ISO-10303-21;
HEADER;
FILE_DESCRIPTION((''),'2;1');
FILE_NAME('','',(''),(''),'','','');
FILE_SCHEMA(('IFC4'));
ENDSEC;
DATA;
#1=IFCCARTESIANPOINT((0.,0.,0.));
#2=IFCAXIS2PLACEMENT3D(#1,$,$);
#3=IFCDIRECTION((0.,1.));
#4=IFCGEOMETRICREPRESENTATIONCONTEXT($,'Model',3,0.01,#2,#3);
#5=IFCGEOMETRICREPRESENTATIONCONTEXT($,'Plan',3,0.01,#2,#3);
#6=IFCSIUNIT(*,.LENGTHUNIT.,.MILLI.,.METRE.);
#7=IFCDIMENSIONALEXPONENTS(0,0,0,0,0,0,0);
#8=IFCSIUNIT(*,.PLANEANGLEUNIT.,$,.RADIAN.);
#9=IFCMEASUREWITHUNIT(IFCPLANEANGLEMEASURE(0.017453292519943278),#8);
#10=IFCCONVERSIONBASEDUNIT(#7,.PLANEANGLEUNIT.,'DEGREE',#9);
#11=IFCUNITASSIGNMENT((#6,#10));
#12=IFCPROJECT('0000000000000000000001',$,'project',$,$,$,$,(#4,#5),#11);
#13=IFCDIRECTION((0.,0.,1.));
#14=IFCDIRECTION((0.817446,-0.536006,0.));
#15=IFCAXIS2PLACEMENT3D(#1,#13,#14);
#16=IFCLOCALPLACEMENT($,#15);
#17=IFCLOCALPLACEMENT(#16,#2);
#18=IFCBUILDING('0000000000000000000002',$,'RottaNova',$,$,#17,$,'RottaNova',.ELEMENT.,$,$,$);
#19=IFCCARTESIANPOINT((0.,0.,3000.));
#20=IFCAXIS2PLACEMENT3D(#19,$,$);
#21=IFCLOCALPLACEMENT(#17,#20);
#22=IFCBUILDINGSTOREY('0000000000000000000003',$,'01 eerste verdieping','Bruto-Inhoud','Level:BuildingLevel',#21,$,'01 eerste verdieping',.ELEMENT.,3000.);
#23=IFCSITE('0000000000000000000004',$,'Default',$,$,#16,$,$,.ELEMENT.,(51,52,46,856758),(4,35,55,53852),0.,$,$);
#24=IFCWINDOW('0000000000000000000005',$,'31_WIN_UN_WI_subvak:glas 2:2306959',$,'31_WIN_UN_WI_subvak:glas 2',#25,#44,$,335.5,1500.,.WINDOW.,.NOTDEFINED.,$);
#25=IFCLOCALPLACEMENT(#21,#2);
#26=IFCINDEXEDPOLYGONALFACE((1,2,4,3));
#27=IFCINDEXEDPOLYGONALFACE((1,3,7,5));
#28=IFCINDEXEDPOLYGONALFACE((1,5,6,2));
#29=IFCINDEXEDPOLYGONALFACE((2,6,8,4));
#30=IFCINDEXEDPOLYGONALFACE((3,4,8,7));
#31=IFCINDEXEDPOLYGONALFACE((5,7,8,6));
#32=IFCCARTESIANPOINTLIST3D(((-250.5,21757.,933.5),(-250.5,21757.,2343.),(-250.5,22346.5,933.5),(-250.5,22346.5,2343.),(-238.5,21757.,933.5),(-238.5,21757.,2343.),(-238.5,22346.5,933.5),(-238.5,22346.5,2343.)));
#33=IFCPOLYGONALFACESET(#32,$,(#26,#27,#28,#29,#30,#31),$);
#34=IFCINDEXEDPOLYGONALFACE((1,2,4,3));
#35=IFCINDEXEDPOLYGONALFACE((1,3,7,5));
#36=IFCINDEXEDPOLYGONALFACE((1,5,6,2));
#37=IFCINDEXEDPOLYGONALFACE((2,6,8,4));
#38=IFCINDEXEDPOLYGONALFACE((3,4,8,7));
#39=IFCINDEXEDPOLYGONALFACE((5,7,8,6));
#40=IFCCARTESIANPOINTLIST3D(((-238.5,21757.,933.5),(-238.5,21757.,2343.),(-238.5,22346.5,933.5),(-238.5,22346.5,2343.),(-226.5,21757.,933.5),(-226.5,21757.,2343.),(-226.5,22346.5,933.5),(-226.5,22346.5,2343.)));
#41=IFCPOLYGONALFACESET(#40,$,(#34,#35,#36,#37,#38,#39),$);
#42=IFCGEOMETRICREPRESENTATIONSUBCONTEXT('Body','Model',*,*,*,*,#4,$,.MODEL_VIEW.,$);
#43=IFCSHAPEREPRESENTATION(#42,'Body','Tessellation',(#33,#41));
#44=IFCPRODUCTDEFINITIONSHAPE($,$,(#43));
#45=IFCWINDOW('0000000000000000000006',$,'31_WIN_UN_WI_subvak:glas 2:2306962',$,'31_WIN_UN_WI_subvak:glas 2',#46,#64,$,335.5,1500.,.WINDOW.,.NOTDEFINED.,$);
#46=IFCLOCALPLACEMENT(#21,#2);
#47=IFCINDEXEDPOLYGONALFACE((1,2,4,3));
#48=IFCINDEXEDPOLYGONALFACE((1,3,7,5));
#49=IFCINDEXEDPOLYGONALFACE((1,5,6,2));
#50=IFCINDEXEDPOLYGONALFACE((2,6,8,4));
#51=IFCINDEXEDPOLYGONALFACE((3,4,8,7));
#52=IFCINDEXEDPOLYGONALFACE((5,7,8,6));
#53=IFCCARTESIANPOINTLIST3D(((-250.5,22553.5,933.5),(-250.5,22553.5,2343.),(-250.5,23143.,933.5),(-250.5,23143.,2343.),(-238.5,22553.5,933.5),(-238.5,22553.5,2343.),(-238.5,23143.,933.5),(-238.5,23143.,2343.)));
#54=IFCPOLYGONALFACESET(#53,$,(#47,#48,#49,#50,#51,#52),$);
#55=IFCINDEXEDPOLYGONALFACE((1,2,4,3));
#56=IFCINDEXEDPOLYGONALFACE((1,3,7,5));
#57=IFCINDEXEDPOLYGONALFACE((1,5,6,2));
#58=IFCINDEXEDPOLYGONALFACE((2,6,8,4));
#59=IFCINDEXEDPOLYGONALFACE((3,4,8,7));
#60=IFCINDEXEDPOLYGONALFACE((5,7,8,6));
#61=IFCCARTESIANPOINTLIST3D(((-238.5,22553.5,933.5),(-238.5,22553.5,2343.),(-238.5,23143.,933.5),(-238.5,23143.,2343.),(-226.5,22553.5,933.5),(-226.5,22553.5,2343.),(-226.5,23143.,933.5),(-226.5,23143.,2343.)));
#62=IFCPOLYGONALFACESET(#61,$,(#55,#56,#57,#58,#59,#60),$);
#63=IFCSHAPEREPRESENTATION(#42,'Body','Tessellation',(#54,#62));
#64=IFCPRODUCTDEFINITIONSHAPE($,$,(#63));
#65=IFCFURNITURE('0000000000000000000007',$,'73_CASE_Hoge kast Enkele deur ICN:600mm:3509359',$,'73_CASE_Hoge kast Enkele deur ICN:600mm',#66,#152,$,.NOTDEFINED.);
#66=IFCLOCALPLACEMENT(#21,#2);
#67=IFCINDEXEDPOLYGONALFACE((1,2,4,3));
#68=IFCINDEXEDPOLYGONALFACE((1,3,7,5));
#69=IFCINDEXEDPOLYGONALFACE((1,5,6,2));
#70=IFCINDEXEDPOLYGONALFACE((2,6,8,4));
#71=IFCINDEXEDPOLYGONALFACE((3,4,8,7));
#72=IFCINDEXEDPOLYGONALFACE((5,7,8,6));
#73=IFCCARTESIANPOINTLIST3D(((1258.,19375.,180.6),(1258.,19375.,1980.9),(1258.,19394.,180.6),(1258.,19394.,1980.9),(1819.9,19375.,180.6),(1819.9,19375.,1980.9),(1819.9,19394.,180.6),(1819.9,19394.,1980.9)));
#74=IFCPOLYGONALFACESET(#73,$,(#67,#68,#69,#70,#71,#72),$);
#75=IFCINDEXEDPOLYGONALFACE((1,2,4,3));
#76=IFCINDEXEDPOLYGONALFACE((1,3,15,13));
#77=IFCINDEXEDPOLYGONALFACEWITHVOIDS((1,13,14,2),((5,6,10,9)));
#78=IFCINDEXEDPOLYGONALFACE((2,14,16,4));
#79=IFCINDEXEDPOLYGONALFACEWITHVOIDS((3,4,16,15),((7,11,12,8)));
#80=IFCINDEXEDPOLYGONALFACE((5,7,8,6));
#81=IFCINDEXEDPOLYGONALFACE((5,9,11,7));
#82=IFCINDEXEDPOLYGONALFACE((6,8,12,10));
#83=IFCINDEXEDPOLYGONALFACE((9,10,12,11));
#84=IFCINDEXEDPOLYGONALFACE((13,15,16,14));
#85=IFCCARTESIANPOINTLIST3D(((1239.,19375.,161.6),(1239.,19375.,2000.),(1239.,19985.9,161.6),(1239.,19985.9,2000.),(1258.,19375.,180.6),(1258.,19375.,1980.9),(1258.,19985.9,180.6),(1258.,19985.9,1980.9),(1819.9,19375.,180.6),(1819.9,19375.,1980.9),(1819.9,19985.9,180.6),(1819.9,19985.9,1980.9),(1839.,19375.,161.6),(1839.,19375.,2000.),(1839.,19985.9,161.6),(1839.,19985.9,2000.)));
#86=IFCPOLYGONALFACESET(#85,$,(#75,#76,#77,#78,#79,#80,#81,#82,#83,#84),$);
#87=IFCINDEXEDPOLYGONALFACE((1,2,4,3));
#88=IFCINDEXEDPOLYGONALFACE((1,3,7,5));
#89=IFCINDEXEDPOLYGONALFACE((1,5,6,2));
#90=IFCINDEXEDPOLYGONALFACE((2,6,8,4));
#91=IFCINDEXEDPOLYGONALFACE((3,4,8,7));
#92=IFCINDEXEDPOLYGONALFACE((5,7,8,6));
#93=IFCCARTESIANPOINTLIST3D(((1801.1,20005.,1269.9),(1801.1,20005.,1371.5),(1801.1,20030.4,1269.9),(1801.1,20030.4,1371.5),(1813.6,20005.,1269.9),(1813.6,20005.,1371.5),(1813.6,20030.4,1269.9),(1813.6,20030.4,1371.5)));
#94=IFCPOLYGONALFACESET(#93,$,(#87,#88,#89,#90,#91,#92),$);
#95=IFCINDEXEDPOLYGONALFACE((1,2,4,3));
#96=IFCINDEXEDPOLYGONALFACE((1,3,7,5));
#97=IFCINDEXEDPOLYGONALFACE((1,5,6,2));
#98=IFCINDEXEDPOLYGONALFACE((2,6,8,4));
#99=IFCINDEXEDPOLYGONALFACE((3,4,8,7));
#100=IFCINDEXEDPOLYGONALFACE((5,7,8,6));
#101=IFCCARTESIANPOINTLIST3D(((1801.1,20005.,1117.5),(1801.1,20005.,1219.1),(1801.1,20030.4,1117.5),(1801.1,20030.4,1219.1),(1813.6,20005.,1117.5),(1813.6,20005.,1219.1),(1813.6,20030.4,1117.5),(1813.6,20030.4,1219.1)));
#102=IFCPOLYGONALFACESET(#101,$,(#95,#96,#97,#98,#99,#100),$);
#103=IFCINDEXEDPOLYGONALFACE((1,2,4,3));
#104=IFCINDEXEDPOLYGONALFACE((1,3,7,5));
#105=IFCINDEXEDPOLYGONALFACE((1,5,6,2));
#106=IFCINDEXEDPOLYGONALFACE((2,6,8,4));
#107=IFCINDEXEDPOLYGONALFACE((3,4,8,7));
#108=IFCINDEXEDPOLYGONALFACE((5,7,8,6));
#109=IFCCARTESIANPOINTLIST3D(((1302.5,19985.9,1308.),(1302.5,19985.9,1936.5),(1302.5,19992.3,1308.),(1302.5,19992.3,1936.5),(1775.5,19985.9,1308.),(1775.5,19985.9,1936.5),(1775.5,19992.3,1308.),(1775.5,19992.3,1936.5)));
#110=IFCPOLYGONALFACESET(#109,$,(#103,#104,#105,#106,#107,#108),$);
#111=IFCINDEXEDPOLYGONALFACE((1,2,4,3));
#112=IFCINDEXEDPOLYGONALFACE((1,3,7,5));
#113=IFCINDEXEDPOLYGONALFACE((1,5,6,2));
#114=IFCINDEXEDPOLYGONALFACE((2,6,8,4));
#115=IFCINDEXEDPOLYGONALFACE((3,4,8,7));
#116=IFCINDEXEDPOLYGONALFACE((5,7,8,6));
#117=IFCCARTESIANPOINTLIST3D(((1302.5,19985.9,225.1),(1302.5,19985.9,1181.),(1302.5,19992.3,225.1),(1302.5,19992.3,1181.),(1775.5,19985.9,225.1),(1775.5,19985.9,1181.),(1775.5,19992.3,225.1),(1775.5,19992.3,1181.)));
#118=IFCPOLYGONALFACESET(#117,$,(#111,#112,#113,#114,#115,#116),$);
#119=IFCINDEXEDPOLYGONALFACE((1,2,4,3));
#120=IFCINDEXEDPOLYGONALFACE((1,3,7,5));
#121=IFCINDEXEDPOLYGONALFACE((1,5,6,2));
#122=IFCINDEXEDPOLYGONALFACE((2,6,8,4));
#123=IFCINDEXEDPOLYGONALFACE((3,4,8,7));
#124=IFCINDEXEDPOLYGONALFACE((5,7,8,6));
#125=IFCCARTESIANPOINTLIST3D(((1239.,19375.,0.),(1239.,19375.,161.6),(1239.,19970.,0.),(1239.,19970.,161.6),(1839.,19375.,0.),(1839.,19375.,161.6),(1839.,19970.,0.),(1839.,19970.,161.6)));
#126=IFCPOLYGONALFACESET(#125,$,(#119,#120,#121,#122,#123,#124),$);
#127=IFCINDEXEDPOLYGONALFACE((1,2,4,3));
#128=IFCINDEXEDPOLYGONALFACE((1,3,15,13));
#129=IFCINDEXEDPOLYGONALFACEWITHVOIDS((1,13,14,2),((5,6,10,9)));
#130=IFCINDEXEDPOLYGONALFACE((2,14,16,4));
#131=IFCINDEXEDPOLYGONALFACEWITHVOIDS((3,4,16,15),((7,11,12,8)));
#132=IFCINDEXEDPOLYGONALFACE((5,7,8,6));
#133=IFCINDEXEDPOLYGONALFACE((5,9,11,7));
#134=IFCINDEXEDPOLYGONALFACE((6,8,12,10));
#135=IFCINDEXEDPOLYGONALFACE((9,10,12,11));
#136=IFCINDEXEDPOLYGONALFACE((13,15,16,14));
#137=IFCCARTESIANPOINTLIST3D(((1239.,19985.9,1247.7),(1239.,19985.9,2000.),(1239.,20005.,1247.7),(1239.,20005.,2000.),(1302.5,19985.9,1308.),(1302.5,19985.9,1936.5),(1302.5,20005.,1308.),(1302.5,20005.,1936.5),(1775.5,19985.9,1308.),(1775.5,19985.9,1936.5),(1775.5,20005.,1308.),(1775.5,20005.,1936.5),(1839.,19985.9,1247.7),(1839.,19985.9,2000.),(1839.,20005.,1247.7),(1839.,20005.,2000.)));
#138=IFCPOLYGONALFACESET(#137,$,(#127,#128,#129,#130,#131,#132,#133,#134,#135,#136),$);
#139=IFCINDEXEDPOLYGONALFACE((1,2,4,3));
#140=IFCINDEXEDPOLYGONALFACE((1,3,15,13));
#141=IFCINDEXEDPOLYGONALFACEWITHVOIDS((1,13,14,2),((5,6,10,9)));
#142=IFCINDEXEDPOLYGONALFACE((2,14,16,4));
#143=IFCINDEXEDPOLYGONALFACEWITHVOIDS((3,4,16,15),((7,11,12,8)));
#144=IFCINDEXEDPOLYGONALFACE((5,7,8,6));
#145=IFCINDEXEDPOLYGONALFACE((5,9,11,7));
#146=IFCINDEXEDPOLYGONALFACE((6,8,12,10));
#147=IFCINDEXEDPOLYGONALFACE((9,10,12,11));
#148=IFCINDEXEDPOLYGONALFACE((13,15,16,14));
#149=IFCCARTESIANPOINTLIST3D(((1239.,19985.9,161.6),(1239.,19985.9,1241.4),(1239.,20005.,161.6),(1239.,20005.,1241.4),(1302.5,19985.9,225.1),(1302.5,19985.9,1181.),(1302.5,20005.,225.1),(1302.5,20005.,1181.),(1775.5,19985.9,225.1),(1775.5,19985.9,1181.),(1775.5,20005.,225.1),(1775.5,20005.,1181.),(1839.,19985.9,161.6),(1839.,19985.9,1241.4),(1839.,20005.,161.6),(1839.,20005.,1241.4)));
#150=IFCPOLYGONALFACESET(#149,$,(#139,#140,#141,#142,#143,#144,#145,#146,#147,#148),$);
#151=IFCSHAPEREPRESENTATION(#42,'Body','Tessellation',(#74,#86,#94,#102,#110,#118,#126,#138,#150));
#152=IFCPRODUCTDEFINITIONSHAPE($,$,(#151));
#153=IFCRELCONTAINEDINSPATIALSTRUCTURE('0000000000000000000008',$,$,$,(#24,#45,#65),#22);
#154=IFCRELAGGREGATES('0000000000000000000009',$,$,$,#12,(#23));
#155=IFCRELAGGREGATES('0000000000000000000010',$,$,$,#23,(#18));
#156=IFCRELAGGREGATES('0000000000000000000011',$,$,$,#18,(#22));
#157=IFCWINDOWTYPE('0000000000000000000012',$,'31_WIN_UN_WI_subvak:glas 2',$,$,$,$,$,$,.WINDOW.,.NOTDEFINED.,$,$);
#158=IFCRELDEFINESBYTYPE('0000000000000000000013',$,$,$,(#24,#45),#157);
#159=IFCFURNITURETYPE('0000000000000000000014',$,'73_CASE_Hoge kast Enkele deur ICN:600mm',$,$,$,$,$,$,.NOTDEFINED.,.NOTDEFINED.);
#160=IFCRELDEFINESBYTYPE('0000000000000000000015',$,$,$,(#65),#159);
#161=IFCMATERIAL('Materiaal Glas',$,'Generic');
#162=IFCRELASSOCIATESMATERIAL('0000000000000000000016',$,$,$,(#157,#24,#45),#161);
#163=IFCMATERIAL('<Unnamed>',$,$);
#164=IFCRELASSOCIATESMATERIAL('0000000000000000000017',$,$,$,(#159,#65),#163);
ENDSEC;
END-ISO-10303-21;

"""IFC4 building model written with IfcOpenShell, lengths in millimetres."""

from ifc_helpers import new_model, entity, si_unit, converted_unit, direction, frame, origin, place, context, subcontext, project, spatial, indexed_curve, outline, extrude, source, transform, mapped, material, type_object, type_shapes, element, save


model = new_model("IFC4")

# Units and contexts
model_context = context("Model", 3, precision=0.01, world=origin(), true_north=direction((0.0, 1.0)))
plan_context = context("Plan", 3, precision=0.01, world=origin(), true_north=direction((0.0, 1.0)))
body_context = subcontext(model_context, "Body", "Model", "MODEL_VIEW")
ifc_project = project(units=[si_unit("LENGTHUNIT", "METRE", prefix="MILLI"), converted_unit("PLANEANGLEUNIT", "DEGREE", entity("IfcPlaneAngleMeasure", 0.017453292519943278), si_unit("PLANEANGLEUNIT", "RADIAN"), dimensions=[0, 0, 0, 0, 0, 0, 0])], contexts=[model_context, plan_context])

# Site, building, storey
site_placement = place(None, frame((0.0, 0.0, 0.0), z_axis=(0.0, 0.0, 1.0), x_axis=(0.817446, -0.536006, 0.0)))
site = spatial("IfcSite", under=ifc_project, at=site_placement, Name="Default", CompositionType="ELEMENT", RefLatitude=(51, 52, 46, 856758), RefLongitude=(4, 35, 55, 53852), RefElevation=0.0)
building_placement = place(site_placement, origin())
building = spatial("IfcBuilding", under=site, at=building_placement, Name="RottaNova", LongName="RottaNova", CompositionType="ELEMENT")
storey_placement = place(building_placement, frame((0.0, 0.0, 3000.0)))
storey = spatial("IfcBuildingStorey", under=building, at=storey_placement, Name="01 eerste verdieping", Description="Bruto-Inhoud", ObjectType="Level:BuildingLevel", LongName="01 eerste verdieping", CompositionType="ELEMENT", Elevation=3000.0)

# Shared definitions
ifc_material_1 = material(Name="Materiaal Glas", Category="Generic")

# Windows
window_type = type_object("IfcWindowType", Name="31_WIN_UN_WI_subvak:glas 2", PartitioningType="NOTDEFINED", PredefinedType="WINDOW", material=ifc_material_1)
shared_shape_1 = source(origin(), body_context, "Body", "SweptSolid", [
    extrude(outline(indexed_curve([(-6.0, -294.7), (6.0, -294.7), (6.0, 294.7), (-6.0, 294.7), (-6.0, -294.7)], self_intersect=False)), frame((0.0, 6.0, 0.0), z_axis=(0.0, 0.0, 1.0), x_axis=(0.0, -1.0, 0.0)), (0.0, 0.0, 1.0), 1409.5),
    extrude(outline(indexed_curve([(-6.0, -294.8), (6.0, -294.8), (6.0, 294.8), (-6.0, 294.8), (-6.0, -294.8)], self_intersect=False)), frame((0.0, -6.0, 0.0), z_axis=(0.0, 0.0, 1.0), x_axis=(0.0, -1.0, 0.0)), (0.0, 0.0, 1.0), 1409.5),
])
type_shapes(window_type, [shared_shape_1])
for number, where, z_axis, x_axis, name in (
    (1, (-238.5, 22051.7, 933.5), (0.0, 0.0, 1.0), (0.0, 1.0, 0.0), "31_WIN_UN_WI_subvak:glas 2:2306959"),
    (2, (-238.5, 22848.2, 933.5), (0.0, 0.0, 1.0), (0.0, 1.0, 0.0), "31_WIN_UN_WI_subvak:glas 2:2306962"),
):
    element("IfcWindow", number, at=place(storey_placement, frame(where, z_axis=z_axis, x_axis=x_axis)), inside=storey, type_object=window_type, material=ifc_material_1, Name=name, ObjectType="31_WIN_UN_WI_subvak:glas 2", OverallHeight=335.5, OverallWidth=1500.0, PartitioningType="NOTDEFINED", PredefinedType="WINDOW", context=body_context, shape_type="MappedRepresentation", body=[
        mapped(shared_shape_1, transform((0.0, 0.0, 0.0), scale=1.0)),
    ])

# Furniture
ifc_material_2 = material(Name="<Unnamed>")
furniture_type = type_object("IfcFurnitureType", Name="73_CASE_Hoge kast Enkele deur ICN:600mm", AssemblyPlace="NOTDEFINED", PredefinedType="NOTDEFINED", material=ifc_material_2)
shared_shape_2 = source(origin(), body_context, "Body", "SweptSolid", [
    extrude(outline(indexed_curve([(-280.9, -9.5), (280.9, -9.5), (280.9, 9.5), (-280.9, 9.5), (-280.9, -9.5)], self_intersect=False)), frame((18.7, 9.5, 180.6), z_axis=(0.0, 0.0, 1.0), x_axis=(-1.0, 0.0, 0.0)), (0.0, 0.0, 1.0), 1800.3),
    extrude(outline(indexed_curve([(-300.0, -919.2), (300.0, -919.2), (300.0, 919.2), (-300.0, 919.2), (-300.0, -919.2)], self_intersect=False), holes=[indexed_curve([(-280.9, 900.2), (281.0, 900.2), (281.0, -900.2), (-280.9, -900.2), (-280.9, 900.2)], self_intersect=False)]), frame((18.7, 0.0, 1080.8), z_axis=(0.0, 1.0, 0.0), x_axis=(-1.0, 0.0, 0.0)), (0.0, 0.0, 1.0), 610.9),
    extrude(outline(indexed_curve([(-6.3, -12.7), (6.3, -12.7), (6.3, 12.7), (-6.3, 12.7), (-6.3, -12.7)], self_intersect=False)), frame((287.1, 642.7, 1269.9), z_axis=(0.0, 0.0, 1.0), x_axis=(-1.0, 0.0, 0.0)), (0.0, 0.0, 1.0), 101.6),
    extrude(outline(indexed_curve([(-6.3, -12.7), (6.3, -12.7), (6.3, 12.7), (-6.3, 12.7), (-6.3, -12.7)], self_intersect=False)), frame((287.1, 642.7, 1117.5), z_axis=(0.0, 0.0, 1.0), x_axis=(-1.0, 0.0, 0.0)), (0.0, 0.0, 1.0), 101.6),
    extrude(outline(indexed_curve([(-236.5, -3.2), (236.5, -3.2), (236.5, 3.2), (-236.5, 3.2), (-236.5, -3.2)], self_intersect=False)), frame((18.7, 614.1, 1308.0), z_axis=(0.0, 0.0, 1.0), x_axis=(-1.0, 0.0, 0.0)), (0.0, 0.0, 1.0), 628.5),
    extrude(outline(indexed_curve([(-236.5, -3.2), (236.5, -3.2), (236.5, 3.2), (-236.5, 3.2), (-236.5, -3.2)], self_intersect=False)), frame((18.7, 614.1, 225.1), z_axis=(0.0, 0.0, 1.0), x_axis=(-1.0, 0.0, 0.0)), (0.0, 0.0, 1.0), 956.0),
    extrude(outline(indexed_curve([(-297.5, -300.0), (297.5, -300.0), (297.5, 300.0), (-297.5, 300.0), (-297.5, -300.0)], self_intersect=False)), frame((18.7, 297.5, 0.0), z_axis=(0.0, 0.0, 1.0), x_axis=(0.0, 1.0, 0.0)), (0.0, 0.0, 1.0), 161.6),
    extrude(outline(indexed_curve([(-376.1, -300.0), (376.1, -300.0), (376.1, 300.0), (-376.1, 300.0), (-376.1, -300.0)], self_intersect=False), holes=[indexed_curve([(-312.6, -236.5), (-312.6, 236.5), (315.8, 236.5), (315.8, -236.5), (-312.6, -236.5)], self_intersect=False)]), frame((18.7, 610.9, 1623.9), z_axis=(0.0, 1.0, 0.0), x_axis=(0.0, 0.0, -1.0)), (0.0, 0.0, 1.0), 19.1),
    extrude(outline(indexed_curve([(-300.0, -539.9), (300.0, -539.9), (300.0, 539.9), (-300.0, 539.9), (-300.0, -539.9)], self_intersect=False), holes=[indexed_curve([(-236.5, 479.6), (236.5, 479.6), (236.5, -476.4), (-236.5, -476.4), (-236.5, 479.6)], self_intersect=False)]), frame((18.7, 610.9, 701.5), z_axis=(0.0, 1.0, 0.0), x_axis=(-1.0, 0.0, 0.0)), (0.0, 0.0, 1.0), 19.1),
])
type_shapes(furniture_type, [shared_shape_2])
for number, where, name in (
    (3, (1520.3, 19375.0, 0.0), "73_CASE_Hoge kast Enkele deur ICN:600mm:3509359"),
):
    element("IfcFurniture", number, at=place(storey_placement, frame(where)), inside=storey, type_object=furniture_type, material=ifc_material_2, Name=name, ObjectType="73_CASE_Hoge kast Enkele deur ICN:600mm", PredefinedType="NOTDEFINED", context=body_context, shape_type="MappedRepresentation", body=[
        mapped(shared_shape_2, transform((0.0, 0.0, 0.0), scale=1.0)),
    ])

save(model, "model.ifc")
